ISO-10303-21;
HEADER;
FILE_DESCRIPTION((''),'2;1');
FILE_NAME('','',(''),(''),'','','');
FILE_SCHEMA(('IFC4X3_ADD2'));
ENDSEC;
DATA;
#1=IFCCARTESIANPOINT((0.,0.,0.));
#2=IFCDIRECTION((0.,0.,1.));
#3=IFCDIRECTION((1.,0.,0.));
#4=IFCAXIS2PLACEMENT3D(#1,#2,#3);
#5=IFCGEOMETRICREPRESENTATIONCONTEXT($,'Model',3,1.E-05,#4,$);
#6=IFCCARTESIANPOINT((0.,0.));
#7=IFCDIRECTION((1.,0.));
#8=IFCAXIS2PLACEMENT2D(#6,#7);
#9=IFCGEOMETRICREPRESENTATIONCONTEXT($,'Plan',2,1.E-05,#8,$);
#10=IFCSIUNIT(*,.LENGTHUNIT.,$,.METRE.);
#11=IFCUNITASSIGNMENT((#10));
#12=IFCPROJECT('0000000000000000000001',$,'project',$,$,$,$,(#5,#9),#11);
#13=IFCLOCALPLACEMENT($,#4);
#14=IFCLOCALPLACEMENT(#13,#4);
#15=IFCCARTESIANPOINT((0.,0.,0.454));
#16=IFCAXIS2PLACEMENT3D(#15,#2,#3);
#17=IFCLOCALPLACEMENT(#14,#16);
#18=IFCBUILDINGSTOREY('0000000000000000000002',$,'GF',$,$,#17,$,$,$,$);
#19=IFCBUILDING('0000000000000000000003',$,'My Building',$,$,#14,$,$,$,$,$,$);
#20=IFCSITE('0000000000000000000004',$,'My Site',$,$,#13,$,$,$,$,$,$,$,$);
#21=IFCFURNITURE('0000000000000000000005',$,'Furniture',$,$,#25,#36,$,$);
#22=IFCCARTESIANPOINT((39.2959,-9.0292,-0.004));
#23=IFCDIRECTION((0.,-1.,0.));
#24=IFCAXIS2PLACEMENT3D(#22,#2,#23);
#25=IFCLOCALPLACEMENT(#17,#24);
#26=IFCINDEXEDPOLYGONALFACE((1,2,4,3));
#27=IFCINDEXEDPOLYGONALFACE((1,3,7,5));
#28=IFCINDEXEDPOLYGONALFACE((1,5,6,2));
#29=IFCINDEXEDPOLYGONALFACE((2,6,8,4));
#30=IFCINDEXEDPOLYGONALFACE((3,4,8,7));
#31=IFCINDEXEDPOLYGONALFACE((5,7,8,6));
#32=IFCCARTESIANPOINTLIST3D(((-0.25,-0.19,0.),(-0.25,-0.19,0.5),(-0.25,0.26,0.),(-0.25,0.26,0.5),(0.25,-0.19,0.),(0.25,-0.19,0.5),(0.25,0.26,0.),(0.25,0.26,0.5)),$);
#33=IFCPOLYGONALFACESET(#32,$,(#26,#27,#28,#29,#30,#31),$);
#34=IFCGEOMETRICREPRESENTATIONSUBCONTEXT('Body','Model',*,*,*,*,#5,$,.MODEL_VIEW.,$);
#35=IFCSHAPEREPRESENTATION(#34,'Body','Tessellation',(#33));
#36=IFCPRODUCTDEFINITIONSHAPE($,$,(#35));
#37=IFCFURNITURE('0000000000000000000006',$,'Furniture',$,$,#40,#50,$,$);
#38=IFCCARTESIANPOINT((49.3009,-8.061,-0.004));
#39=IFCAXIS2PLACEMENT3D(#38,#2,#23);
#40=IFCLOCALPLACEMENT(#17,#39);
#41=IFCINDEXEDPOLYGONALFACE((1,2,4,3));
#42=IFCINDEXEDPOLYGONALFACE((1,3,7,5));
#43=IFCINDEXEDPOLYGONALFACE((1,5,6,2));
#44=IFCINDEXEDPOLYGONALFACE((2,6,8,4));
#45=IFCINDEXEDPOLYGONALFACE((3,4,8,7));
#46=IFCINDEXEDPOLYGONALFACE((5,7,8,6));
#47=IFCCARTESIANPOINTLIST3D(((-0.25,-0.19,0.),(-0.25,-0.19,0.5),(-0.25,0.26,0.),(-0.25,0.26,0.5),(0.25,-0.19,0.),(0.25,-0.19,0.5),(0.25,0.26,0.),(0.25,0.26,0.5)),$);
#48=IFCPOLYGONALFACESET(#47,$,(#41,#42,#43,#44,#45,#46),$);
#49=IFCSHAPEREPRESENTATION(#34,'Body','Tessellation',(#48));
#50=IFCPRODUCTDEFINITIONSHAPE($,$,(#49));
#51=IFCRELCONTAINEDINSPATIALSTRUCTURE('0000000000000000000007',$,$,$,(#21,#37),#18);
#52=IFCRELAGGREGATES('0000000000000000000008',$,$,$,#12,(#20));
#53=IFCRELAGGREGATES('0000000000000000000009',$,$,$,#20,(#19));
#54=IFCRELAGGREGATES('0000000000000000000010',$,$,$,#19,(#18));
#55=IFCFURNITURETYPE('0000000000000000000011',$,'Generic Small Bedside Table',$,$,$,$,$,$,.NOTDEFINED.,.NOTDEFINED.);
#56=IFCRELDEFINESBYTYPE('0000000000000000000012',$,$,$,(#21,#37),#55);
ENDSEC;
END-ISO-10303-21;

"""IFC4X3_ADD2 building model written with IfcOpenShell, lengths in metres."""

from ifc_helpers import new_model, entity, si_unit, frame, origin_with_axes, origin_2d_with_axis, place, context, subcontext, project, spatial, line, indexed_curve, outline, extrude, shape, source, transform, mapped, type_object, type_shapes, element, save


model = new_model("IFC4X3_ADD2")

# Units and contexts
model_context = context("Model", 3, precision=1e-05, world=origin_with_axes())
plan_context = context("Plan", 2, precision=1e-05, world=origin_2d_with_axis())
body_context_1 = subcontext(model_context, "Body", "Model", "MODEL_VIEW")
body_context_2 = subcontext(plan_context, "Body", "Plan", "PLAN_VIEW")
ifc_project = project(units=[si_unit("LENGTHUNIT", "METRE")], contexts=[model_context, plan_context])

# Site, building, storey
site_placement = place(None, origin_with_axes())
site = spatial("IfcSite", under=ifc_project, at=site_placement, Name="My Site")
building_placement = place(site_placement, origin_with_axes())
building = spatial("IfcBuilding", under=site, at=building_placement, Name="My Building")
storey_placement = place(building_placement, frame((0.0, 0.0, 0.454), z_axis=(0.0, 0.0, 1.0), x_axis=(1.0, 0.0, 0.0)))
storey = spatial("IfcBuildingStorey", under=building, at=storey_placement, Name="GF")

# Furniture
furniture_type_1 = type_object("IfcFurnitureType", Name="Generic Small Bedside Table", AssemblyPlace="NOTDEFINED", PredefinedType="NOTDEFINED")
shared_shape_1 = source(origin_with_axes(), body_context_1, "Body", "SweptSolid", [
    extrude(outline(indexed_curve([(0.5, 0.45), (0.5, 0.0), (0.0, 0.0), (0.0, 0.45)], segments=[line(4, 1), line(1, 2), line(2, 3), line(3, 4)], self_intersect=False)), frame((-0.25, -0.19, 0.0), z_axis=(0.0, 0.0, 1.0), x_axis=(1.0, 0.0, 0.0)), (0.0, 0.0, 1.0), 0.5),
])
shared_shape_2 = source(origin_with_axes(), body_context_2, "Body", "Annotation2D", [
    entity("IfcGeometricCurveSet", [entity("IfcIndexedPolyCurve", entity("IfcCartesianPointList2D", [[-0.25, -0.19], [0.25, -0.19], [0.25, 0.26], [-0.25, 0.26]]), [entity("IfcLineIndex", [1, 2]), entity("IfcLineIndex", [2, 3]), entity("IfcLineIndex", [3, 4]), entity("IfcLineIndex", [4, 1])])]),
])
type_shapes(furniture_type_1, [shared_shape_1, shared_shape_2])
for number, where, z_axis, x_axis, name in (
    (1, (39.2959, -9.0292, -0.004), (0.0, 0.0, 1.0), (0.0, -1.0, 0.0), "Furniture"),
    (2, (49.3009, -8.061, -0.004), (0.0, 0.0, 1.0), (0.0, -1.0, 0.0), "Furniture"),
):
    element("IfcFurniture", number, at=place(storey_placement, frame(where, z_axis=z_axis, x_axis=x_axis)), inside=storey, type_object=furniture_type_1, Name=name, shapes=[
        shape(body_context_1, "Body", "MappedRepresentation", [mapped(shared_shape_1, transform((0.0, 0.0, 0.0), x_axis=(1.0, 0.0, 0.0), y_axis=(0.0, 1.0, 0.0), z_axis=(0.0, 0.0, 1.0), scale=1.0))]),
        shape(body_context_2, "Body", "MappedRepresentation", [mapped(shared_shape_2, transform((0.0, 0.0, 0.0), x_axis=(1.0, 0.0, 0.0), y_axis=(0.0, 1.0, 0.0), z_axis=(0.0, 0.0, 1.0), scale=1.0))]),
    ])

save(model, "model.ifc")
